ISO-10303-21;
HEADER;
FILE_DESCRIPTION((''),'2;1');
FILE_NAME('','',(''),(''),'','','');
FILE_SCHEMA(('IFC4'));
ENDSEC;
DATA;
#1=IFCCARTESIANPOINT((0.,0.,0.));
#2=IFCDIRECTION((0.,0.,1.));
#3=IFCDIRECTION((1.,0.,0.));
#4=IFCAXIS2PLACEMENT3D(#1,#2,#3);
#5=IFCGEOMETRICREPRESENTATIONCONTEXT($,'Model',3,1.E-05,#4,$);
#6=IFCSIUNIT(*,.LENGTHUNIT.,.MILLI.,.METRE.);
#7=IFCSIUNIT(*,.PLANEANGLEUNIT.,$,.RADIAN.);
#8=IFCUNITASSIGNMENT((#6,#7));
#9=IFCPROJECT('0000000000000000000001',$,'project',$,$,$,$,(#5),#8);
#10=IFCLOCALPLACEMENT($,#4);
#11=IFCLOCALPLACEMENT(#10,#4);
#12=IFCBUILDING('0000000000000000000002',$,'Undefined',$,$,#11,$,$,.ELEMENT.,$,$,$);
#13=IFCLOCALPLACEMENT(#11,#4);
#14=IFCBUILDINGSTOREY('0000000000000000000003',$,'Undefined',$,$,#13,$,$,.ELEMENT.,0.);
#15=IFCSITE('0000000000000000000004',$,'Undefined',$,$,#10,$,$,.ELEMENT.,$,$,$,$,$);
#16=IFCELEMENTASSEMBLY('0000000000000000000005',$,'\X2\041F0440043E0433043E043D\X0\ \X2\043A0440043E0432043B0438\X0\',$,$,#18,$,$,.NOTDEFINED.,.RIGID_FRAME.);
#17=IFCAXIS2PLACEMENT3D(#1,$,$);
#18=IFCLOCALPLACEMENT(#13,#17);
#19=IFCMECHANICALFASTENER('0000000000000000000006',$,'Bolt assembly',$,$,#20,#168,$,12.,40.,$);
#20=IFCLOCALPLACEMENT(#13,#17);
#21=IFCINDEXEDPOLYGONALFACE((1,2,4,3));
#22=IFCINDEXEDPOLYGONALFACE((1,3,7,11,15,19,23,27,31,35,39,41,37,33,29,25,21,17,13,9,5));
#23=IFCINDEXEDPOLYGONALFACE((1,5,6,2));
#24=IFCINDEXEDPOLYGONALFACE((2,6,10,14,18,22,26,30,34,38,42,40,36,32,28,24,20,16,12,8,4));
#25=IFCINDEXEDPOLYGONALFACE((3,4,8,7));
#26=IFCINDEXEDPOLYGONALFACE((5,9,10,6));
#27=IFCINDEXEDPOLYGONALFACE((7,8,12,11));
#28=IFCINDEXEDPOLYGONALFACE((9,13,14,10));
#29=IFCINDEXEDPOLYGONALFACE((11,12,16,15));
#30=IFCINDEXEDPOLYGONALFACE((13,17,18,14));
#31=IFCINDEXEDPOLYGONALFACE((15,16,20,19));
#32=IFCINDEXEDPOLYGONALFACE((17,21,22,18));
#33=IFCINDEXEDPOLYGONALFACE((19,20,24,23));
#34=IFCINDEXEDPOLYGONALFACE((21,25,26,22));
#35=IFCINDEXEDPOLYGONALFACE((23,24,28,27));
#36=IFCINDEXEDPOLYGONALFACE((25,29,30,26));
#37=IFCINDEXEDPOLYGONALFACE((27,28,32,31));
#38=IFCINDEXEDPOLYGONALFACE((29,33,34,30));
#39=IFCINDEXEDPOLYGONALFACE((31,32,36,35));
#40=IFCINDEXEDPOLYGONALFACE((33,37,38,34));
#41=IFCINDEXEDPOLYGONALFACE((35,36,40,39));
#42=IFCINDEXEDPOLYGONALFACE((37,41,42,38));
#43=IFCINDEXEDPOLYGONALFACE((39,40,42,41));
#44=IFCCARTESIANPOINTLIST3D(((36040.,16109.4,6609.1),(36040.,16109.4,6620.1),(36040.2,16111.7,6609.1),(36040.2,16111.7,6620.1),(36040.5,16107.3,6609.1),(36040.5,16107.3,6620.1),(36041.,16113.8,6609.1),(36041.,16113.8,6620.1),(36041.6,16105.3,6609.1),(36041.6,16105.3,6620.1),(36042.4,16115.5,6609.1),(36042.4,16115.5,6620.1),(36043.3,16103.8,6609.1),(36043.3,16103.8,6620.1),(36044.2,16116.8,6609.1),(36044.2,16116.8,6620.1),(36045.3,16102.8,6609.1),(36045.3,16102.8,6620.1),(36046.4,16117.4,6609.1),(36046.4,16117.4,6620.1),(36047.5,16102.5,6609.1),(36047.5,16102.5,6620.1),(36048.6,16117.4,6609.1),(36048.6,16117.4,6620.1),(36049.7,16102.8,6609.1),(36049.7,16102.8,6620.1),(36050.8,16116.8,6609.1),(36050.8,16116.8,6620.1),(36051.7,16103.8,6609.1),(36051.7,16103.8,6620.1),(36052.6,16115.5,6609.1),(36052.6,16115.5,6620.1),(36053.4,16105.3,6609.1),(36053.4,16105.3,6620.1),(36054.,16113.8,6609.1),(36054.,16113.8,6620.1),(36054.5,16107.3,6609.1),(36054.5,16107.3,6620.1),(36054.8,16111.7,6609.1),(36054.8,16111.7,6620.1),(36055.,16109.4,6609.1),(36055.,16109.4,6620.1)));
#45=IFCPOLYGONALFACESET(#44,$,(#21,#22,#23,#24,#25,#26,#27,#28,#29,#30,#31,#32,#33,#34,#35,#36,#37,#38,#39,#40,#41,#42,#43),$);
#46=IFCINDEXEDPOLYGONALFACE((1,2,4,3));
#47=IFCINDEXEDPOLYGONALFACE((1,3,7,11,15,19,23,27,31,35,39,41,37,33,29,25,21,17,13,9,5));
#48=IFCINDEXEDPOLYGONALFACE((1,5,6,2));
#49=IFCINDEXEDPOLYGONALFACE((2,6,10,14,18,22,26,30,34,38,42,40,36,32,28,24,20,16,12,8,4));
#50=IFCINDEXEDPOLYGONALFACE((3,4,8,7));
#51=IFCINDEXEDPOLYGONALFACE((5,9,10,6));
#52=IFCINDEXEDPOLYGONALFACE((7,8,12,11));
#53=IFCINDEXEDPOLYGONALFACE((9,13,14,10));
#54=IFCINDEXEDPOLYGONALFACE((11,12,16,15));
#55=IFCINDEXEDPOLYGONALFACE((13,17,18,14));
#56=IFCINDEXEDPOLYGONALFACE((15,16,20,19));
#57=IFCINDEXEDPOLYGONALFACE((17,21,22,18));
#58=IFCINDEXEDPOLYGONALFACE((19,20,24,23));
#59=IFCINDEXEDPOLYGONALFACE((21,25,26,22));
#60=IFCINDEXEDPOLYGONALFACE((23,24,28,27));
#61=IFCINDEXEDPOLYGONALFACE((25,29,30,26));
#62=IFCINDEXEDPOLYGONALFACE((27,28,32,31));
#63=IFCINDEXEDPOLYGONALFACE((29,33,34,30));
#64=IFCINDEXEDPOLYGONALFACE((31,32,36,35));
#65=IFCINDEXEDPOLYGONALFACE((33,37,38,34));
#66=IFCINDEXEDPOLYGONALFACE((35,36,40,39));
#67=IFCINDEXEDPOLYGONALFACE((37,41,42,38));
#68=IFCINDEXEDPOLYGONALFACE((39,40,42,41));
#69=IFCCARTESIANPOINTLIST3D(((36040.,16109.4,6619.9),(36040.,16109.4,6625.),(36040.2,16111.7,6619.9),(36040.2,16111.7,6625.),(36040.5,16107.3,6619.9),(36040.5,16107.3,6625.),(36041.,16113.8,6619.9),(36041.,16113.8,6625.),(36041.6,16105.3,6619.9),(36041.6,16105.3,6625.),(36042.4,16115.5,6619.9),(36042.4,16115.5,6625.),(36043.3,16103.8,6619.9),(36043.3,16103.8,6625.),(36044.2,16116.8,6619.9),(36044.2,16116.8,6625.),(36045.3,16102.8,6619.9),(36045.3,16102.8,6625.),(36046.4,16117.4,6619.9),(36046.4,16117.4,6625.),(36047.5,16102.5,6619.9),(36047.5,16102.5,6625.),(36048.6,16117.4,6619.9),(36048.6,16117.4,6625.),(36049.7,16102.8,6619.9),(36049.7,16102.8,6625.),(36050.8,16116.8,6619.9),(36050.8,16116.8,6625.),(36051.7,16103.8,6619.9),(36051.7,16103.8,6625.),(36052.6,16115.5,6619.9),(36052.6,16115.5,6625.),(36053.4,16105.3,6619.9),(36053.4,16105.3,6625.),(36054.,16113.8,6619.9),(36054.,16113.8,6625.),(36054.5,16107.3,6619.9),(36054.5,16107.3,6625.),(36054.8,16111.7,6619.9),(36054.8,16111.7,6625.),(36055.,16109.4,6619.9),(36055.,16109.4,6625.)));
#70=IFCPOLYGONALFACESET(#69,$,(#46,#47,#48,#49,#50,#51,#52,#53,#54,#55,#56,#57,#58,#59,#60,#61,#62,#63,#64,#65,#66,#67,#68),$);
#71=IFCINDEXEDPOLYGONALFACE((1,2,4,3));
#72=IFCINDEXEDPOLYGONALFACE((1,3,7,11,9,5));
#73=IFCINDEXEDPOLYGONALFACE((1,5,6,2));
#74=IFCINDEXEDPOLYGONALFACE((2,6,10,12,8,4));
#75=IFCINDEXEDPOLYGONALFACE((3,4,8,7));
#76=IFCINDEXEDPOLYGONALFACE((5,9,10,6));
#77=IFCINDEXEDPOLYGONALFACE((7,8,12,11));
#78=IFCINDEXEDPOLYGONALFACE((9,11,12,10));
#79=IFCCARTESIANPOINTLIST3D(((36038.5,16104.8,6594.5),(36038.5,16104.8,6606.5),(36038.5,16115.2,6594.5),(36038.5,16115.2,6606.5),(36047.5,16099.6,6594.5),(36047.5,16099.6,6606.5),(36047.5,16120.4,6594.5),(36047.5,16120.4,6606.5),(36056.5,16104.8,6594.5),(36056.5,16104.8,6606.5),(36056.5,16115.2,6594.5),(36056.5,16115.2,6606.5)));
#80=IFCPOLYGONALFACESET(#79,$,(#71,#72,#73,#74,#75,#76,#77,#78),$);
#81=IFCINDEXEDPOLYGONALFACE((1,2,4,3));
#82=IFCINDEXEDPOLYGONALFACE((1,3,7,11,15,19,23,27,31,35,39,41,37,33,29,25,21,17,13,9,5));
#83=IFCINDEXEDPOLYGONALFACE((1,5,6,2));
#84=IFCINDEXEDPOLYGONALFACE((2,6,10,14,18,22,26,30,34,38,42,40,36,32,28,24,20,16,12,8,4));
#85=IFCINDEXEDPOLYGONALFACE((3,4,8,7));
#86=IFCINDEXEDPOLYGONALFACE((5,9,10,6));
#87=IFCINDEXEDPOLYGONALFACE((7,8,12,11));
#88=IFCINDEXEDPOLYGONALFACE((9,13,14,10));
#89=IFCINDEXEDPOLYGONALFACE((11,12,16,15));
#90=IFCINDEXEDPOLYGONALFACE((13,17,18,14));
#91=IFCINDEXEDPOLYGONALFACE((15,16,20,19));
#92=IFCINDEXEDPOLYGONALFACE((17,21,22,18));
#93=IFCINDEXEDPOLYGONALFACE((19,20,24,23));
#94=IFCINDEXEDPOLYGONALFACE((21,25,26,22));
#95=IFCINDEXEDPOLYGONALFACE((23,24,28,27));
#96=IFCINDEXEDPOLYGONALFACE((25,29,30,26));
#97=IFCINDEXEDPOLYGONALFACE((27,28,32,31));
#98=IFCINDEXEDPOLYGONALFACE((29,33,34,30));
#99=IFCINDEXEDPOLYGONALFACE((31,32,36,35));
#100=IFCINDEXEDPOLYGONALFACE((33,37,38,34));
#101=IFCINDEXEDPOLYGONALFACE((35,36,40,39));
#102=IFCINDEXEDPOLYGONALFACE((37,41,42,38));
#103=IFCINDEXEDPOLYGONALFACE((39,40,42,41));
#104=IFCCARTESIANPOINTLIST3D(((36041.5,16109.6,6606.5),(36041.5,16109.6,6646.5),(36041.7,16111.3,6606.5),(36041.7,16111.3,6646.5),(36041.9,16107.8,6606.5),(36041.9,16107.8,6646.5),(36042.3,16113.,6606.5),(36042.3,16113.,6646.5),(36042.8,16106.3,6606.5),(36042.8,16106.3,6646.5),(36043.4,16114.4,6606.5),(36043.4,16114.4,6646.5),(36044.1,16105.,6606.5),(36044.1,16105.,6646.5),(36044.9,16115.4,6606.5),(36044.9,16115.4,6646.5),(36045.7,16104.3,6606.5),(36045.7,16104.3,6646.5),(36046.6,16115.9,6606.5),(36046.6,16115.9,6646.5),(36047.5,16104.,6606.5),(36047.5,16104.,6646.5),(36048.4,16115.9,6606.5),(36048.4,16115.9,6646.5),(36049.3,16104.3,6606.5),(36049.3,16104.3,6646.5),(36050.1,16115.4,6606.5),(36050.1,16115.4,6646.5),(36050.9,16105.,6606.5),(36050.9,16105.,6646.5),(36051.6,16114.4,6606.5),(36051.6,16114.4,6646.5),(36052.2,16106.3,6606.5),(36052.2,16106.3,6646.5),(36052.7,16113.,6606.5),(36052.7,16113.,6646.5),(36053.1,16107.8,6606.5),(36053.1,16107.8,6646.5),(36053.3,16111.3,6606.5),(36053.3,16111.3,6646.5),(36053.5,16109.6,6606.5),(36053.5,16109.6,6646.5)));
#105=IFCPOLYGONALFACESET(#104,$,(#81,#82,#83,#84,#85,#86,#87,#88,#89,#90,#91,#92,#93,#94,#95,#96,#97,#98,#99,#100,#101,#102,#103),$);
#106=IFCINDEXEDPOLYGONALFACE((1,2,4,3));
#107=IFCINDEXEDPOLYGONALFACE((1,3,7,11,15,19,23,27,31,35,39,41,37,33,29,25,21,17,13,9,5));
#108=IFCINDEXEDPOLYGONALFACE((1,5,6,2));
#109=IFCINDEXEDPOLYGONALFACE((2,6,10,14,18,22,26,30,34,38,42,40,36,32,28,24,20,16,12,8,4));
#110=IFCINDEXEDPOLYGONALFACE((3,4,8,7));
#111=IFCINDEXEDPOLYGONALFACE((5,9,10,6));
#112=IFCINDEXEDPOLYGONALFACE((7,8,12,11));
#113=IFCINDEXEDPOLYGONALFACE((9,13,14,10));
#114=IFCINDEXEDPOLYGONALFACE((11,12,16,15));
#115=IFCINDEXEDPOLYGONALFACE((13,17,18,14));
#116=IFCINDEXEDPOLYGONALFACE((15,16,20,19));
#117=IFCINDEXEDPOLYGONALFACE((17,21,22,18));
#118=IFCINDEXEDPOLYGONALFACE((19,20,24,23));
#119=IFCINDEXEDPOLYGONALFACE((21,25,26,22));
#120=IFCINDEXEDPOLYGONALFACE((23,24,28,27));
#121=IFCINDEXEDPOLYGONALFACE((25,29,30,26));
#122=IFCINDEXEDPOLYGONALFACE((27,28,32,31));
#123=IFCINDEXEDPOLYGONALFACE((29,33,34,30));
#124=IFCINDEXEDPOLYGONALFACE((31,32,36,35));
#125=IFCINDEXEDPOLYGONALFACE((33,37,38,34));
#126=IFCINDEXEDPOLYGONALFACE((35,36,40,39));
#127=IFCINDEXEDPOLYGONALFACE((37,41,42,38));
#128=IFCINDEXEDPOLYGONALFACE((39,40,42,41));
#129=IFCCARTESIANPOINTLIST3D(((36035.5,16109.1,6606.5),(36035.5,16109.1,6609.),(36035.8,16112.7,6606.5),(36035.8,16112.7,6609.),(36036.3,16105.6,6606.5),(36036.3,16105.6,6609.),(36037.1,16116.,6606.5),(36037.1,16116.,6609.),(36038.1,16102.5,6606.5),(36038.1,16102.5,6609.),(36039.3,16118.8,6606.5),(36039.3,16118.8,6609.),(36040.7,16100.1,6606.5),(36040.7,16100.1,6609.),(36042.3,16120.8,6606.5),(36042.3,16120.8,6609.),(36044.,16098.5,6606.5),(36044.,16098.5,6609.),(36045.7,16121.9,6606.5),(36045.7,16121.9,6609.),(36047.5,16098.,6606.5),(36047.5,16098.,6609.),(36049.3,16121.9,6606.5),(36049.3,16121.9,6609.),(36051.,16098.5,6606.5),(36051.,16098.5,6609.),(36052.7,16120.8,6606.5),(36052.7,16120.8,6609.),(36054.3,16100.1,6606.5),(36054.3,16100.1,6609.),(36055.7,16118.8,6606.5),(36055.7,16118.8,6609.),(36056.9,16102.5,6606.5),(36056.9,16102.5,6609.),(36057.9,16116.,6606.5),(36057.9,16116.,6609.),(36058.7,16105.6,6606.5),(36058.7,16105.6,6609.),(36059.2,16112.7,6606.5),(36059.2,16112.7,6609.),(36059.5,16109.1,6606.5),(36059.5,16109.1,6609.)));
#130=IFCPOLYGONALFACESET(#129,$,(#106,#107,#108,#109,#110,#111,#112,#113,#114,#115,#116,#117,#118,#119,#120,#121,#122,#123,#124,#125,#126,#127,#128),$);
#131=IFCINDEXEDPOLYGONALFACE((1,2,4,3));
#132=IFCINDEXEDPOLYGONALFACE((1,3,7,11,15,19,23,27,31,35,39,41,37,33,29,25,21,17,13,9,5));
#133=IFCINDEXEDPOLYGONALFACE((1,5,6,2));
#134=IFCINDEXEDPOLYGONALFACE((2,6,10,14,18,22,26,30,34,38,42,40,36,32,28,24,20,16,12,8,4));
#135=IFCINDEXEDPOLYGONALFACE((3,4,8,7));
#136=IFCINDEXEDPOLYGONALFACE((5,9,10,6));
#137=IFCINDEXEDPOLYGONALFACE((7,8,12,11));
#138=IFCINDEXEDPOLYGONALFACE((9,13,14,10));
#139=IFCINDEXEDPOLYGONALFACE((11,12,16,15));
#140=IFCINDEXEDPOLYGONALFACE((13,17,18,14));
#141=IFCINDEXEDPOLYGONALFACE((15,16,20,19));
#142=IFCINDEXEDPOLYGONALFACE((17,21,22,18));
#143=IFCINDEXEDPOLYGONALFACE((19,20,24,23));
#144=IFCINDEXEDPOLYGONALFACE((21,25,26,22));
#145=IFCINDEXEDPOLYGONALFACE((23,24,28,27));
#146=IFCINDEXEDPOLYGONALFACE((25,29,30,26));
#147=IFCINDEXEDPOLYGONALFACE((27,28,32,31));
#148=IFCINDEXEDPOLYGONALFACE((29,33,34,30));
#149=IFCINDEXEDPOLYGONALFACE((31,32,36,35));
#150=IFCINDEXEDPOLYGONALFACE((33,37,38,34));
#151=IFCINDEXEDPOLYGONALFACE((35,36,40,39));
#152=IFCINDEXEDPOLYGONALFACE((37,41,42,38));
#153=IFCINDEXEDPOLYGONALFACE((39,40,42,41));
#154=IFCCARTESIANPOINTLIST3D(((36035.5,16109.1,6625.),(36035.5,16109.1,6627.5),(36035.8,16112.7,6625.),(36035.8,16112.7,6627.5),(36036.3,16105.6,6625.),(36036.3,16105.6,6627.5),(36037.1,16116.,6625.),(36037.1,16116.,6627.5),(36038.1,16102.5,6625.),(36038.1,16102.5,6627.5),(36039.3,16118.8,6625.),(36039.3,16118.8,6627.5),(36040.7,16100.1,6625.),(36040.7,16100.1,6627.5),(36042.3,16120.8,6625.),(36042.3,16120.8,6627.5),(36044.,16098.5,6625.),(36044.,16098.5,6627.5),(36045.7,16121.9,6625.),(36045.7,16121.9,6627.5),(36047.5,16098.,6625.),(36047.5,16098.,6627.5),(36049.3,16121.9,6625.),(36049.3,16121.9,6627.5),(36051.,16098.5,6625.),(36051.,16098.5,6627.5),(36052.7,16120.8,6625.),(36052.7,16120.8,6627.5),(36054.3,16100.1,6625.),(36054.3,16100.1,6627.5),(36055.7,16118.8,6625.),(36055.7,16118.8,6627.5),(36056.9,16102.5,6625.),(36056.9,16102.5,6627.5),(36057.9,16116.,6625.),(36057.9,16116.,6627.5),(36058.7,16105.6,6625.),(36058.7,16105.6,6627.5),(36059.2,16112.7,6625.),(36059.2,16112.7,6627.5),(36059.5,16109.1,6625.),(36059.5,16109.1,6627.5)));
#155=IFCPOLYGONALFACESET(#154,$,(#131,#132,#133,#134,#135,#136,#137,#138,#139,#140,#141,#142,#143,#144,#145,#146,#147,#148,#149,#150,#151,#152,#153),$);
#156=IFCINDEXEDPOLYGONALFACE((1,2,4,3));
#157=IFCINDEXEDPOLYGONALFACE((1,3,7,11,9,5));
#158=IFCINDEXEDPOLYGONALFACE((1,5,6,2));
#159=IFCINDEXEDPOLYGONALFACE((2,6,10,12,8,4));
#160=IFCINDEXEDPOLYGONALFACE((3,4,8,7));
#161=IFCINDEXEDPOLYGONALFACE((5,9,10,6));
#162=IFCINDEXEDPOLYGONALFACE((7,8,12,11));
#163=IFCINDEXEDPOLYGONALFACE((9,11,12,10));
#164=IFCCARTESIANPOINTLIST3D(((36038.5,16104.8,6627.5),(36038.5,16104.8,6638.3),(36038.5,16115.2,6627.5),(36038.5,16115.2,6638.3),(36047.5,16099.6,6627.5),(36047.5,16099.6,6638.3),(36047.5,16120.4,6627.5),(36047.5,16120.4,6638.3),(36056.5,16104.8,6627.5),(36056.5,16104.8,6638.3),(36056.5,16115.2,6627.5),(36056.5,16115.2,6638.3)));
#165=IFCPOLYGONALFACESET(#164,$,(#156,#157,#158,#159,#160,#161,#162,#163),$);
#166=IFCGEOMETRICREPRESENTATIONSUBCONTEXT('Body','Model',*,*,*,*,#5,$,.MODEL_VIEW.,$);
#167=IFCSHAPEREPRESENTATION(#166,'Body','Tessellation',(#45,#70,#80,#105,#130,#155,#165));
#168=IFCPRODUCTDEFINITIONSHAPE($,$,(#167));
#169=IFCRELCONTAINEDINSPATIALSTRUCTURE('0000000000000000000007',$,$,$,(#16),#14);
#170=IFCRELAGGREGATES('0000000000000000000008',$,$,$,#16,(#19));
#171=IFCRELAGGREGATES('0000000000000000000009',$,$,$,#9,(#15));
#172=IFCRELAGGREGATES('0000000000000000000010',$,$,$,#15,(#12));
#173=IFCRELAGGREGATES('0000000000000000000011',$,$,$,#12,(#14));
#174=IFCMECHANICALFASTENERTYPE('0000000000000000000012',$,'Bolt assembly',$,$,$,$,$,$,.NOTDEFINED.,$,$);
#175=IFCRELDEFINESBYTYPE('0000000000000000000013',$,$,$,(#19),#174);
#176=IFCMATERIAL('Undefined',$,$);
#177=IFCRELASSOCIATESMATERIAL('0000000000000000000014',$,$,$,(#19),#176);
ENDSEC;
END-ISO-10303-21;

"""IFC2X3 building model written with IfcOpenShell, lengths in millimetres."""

from ifc_helpers import new_model, si_unit, frame, origin_with_axes, origin_2d_with_axis, place, context, subcontext, project, spatial, polyline, circle, outline, extrude, source, transform, mapped, material, type_object, element, aggregate, save


model = new_model("IFC2X3")

# Units and contexts
model_context = context("Model", 3, precision=1e-05, world=origin_with_axes())
body_context = subcontext(model_context, "Body", "Model", "MODEL_VIEW")
ifc_project = project(units=[si_unit("LENGTHUNIT", "METRE", prefix="MILLI"), si_unit("PLANEANGLEUNIT", "RADIAN")], contexts=[model_context])

# Site, building, storey
site_placement = place(None, origin_with_axes())
site = spatial("IfcSite", under=ifc_project, at=site_placement, Name="Undefined", CompositionType="ELEMENT")
building_placement = place(site_placement, origin_with_axes())
building = spatial("IfcBuilding", under=site, at=building_placement, Name="Undefined", CompositionType="ELEMENT")
storey_placement = place(building_placement, origin_with_axes())
storey = spatial("IfcBuildingStorey", under=building, at=storey_placement, Name="Undefined", CompositionType="ELEMENT", Elevation=0.0)

# Element assembly
assembly_1_placement = place(storey_placement, origin_with_axes())
assembly_1 = element("IfcElementAssembly", 1, at=assembly_1_placement, inside=storey, Name="Прогон кровли", AssemblyPlace="NOTDEFINED", PredefinedType="RIGID_FRAME")

# Mechanical fastener
ifc_material_1 = material(Name="Undefined")
mechanical_fastener_type = type_object("IfcMechanicalFastenerType", Name="Bolt assembly")
shared_shape_1 = source(origin_with_axes(), body_context, "Body", "SweptSolid", [
    extrude(circle(Radius=7.5, at=origin_2d_with_axis()), frame((0.0, -10.9, 0.0), z_axis=(0.0, 1.0, 0.0), x_axis=(1.0, 0.0, 0.0)), (0.0, 0.0, 1.0), 11.0),
    extrude(circle(Radius=7.5, at=origin_2d_with_axis()), frame((0.0, -0.1, 0.0), z_axis=(0.0, 1.0, 0.0), x_axis=(1.0, 0.0, 0.0)), (0.0, 0.0, 1.0), 5.1),
    extrude(outline(polyline([(10.4, 0.0), (5.2, 9.0), (-5.2, 9.0), (-10.4, 0.0), (-5.2, -9.0), (5.2, -9.0), (10.4, 0.0)])), frame((0.0, -25.5, 0.0), z_axis=(0.0, 1.0, 0.0), x_axis=(1.0, 0.0, 0.0)), (0.0, 0.0, 1.0), 12.0),
    extrude(circle(Radius=6.0, at=origin_2d_with_axis()), frame((0.0, -13.5, 0.0), z_axis=(0.0, 1.0, 0.0), x_axis=(1.0, 0.0, 0.0)), (0.0, 0.0, 1.0), 40.0),
    extrude(circle(Radius=12.0, at=origin_2d_with_axis()), frame((0.0, -13.5, 0.0), z_axis=(0.0, 1.0, 0.0), x_axis=(1.0, 0.0, 0.0)), (0.0, 0.0, 1.0), 2.5),
    extrude(circle(Radius=12.0, at=origin_2d_with_axis()), frame((0.0, 5.0, 0.0), z_axis=(0.0, 1.0, 0.0), x_axis=(1.0, 0.0, 0.0)), (0.0, 0.0, 1.0), 2.5),
    extrude(outline(polyline([(10.4, 0.0), (5.2, 9.0), (-5.2, 9.0), (-10.4, 0.0), (-5.2, -9.0), (5.2, -9.0), (10.4, 0.0)])), frame((0.0, 7.5, 0.0), z_axis=(0.0, 1.0, 0.0), x_axis=(1.0, 0.0, 0.0)), (0.0, 0.0, 1.0), 10.8),
])
mechanical_fastener_1_placement = place(assembly_1_placement, frame((36047.5, 16110.0, 6620.0), z_axis=(-1.0, 0.0, 0.0), x_axis=(0.0, -1.0, 0.0)))
mechanical_fastener_1 = element("IfcMechanicalFastener", 2, at=mechanical_fastener_1_placement, type_object=mechanical_fastener_type, material=ifc_material_1, Name="Bolt assembly", NominalDiameter=12.0, NominalLength=40.0, context=body_context, shape_type="MappedRepresentation", body=[
    mapped(shared_shape_1, transform((0.0, 0.0, 0.0))),
])
aggregate(assembly_1, [mechanical_fastener_1])

save(model, "model.ifc")
